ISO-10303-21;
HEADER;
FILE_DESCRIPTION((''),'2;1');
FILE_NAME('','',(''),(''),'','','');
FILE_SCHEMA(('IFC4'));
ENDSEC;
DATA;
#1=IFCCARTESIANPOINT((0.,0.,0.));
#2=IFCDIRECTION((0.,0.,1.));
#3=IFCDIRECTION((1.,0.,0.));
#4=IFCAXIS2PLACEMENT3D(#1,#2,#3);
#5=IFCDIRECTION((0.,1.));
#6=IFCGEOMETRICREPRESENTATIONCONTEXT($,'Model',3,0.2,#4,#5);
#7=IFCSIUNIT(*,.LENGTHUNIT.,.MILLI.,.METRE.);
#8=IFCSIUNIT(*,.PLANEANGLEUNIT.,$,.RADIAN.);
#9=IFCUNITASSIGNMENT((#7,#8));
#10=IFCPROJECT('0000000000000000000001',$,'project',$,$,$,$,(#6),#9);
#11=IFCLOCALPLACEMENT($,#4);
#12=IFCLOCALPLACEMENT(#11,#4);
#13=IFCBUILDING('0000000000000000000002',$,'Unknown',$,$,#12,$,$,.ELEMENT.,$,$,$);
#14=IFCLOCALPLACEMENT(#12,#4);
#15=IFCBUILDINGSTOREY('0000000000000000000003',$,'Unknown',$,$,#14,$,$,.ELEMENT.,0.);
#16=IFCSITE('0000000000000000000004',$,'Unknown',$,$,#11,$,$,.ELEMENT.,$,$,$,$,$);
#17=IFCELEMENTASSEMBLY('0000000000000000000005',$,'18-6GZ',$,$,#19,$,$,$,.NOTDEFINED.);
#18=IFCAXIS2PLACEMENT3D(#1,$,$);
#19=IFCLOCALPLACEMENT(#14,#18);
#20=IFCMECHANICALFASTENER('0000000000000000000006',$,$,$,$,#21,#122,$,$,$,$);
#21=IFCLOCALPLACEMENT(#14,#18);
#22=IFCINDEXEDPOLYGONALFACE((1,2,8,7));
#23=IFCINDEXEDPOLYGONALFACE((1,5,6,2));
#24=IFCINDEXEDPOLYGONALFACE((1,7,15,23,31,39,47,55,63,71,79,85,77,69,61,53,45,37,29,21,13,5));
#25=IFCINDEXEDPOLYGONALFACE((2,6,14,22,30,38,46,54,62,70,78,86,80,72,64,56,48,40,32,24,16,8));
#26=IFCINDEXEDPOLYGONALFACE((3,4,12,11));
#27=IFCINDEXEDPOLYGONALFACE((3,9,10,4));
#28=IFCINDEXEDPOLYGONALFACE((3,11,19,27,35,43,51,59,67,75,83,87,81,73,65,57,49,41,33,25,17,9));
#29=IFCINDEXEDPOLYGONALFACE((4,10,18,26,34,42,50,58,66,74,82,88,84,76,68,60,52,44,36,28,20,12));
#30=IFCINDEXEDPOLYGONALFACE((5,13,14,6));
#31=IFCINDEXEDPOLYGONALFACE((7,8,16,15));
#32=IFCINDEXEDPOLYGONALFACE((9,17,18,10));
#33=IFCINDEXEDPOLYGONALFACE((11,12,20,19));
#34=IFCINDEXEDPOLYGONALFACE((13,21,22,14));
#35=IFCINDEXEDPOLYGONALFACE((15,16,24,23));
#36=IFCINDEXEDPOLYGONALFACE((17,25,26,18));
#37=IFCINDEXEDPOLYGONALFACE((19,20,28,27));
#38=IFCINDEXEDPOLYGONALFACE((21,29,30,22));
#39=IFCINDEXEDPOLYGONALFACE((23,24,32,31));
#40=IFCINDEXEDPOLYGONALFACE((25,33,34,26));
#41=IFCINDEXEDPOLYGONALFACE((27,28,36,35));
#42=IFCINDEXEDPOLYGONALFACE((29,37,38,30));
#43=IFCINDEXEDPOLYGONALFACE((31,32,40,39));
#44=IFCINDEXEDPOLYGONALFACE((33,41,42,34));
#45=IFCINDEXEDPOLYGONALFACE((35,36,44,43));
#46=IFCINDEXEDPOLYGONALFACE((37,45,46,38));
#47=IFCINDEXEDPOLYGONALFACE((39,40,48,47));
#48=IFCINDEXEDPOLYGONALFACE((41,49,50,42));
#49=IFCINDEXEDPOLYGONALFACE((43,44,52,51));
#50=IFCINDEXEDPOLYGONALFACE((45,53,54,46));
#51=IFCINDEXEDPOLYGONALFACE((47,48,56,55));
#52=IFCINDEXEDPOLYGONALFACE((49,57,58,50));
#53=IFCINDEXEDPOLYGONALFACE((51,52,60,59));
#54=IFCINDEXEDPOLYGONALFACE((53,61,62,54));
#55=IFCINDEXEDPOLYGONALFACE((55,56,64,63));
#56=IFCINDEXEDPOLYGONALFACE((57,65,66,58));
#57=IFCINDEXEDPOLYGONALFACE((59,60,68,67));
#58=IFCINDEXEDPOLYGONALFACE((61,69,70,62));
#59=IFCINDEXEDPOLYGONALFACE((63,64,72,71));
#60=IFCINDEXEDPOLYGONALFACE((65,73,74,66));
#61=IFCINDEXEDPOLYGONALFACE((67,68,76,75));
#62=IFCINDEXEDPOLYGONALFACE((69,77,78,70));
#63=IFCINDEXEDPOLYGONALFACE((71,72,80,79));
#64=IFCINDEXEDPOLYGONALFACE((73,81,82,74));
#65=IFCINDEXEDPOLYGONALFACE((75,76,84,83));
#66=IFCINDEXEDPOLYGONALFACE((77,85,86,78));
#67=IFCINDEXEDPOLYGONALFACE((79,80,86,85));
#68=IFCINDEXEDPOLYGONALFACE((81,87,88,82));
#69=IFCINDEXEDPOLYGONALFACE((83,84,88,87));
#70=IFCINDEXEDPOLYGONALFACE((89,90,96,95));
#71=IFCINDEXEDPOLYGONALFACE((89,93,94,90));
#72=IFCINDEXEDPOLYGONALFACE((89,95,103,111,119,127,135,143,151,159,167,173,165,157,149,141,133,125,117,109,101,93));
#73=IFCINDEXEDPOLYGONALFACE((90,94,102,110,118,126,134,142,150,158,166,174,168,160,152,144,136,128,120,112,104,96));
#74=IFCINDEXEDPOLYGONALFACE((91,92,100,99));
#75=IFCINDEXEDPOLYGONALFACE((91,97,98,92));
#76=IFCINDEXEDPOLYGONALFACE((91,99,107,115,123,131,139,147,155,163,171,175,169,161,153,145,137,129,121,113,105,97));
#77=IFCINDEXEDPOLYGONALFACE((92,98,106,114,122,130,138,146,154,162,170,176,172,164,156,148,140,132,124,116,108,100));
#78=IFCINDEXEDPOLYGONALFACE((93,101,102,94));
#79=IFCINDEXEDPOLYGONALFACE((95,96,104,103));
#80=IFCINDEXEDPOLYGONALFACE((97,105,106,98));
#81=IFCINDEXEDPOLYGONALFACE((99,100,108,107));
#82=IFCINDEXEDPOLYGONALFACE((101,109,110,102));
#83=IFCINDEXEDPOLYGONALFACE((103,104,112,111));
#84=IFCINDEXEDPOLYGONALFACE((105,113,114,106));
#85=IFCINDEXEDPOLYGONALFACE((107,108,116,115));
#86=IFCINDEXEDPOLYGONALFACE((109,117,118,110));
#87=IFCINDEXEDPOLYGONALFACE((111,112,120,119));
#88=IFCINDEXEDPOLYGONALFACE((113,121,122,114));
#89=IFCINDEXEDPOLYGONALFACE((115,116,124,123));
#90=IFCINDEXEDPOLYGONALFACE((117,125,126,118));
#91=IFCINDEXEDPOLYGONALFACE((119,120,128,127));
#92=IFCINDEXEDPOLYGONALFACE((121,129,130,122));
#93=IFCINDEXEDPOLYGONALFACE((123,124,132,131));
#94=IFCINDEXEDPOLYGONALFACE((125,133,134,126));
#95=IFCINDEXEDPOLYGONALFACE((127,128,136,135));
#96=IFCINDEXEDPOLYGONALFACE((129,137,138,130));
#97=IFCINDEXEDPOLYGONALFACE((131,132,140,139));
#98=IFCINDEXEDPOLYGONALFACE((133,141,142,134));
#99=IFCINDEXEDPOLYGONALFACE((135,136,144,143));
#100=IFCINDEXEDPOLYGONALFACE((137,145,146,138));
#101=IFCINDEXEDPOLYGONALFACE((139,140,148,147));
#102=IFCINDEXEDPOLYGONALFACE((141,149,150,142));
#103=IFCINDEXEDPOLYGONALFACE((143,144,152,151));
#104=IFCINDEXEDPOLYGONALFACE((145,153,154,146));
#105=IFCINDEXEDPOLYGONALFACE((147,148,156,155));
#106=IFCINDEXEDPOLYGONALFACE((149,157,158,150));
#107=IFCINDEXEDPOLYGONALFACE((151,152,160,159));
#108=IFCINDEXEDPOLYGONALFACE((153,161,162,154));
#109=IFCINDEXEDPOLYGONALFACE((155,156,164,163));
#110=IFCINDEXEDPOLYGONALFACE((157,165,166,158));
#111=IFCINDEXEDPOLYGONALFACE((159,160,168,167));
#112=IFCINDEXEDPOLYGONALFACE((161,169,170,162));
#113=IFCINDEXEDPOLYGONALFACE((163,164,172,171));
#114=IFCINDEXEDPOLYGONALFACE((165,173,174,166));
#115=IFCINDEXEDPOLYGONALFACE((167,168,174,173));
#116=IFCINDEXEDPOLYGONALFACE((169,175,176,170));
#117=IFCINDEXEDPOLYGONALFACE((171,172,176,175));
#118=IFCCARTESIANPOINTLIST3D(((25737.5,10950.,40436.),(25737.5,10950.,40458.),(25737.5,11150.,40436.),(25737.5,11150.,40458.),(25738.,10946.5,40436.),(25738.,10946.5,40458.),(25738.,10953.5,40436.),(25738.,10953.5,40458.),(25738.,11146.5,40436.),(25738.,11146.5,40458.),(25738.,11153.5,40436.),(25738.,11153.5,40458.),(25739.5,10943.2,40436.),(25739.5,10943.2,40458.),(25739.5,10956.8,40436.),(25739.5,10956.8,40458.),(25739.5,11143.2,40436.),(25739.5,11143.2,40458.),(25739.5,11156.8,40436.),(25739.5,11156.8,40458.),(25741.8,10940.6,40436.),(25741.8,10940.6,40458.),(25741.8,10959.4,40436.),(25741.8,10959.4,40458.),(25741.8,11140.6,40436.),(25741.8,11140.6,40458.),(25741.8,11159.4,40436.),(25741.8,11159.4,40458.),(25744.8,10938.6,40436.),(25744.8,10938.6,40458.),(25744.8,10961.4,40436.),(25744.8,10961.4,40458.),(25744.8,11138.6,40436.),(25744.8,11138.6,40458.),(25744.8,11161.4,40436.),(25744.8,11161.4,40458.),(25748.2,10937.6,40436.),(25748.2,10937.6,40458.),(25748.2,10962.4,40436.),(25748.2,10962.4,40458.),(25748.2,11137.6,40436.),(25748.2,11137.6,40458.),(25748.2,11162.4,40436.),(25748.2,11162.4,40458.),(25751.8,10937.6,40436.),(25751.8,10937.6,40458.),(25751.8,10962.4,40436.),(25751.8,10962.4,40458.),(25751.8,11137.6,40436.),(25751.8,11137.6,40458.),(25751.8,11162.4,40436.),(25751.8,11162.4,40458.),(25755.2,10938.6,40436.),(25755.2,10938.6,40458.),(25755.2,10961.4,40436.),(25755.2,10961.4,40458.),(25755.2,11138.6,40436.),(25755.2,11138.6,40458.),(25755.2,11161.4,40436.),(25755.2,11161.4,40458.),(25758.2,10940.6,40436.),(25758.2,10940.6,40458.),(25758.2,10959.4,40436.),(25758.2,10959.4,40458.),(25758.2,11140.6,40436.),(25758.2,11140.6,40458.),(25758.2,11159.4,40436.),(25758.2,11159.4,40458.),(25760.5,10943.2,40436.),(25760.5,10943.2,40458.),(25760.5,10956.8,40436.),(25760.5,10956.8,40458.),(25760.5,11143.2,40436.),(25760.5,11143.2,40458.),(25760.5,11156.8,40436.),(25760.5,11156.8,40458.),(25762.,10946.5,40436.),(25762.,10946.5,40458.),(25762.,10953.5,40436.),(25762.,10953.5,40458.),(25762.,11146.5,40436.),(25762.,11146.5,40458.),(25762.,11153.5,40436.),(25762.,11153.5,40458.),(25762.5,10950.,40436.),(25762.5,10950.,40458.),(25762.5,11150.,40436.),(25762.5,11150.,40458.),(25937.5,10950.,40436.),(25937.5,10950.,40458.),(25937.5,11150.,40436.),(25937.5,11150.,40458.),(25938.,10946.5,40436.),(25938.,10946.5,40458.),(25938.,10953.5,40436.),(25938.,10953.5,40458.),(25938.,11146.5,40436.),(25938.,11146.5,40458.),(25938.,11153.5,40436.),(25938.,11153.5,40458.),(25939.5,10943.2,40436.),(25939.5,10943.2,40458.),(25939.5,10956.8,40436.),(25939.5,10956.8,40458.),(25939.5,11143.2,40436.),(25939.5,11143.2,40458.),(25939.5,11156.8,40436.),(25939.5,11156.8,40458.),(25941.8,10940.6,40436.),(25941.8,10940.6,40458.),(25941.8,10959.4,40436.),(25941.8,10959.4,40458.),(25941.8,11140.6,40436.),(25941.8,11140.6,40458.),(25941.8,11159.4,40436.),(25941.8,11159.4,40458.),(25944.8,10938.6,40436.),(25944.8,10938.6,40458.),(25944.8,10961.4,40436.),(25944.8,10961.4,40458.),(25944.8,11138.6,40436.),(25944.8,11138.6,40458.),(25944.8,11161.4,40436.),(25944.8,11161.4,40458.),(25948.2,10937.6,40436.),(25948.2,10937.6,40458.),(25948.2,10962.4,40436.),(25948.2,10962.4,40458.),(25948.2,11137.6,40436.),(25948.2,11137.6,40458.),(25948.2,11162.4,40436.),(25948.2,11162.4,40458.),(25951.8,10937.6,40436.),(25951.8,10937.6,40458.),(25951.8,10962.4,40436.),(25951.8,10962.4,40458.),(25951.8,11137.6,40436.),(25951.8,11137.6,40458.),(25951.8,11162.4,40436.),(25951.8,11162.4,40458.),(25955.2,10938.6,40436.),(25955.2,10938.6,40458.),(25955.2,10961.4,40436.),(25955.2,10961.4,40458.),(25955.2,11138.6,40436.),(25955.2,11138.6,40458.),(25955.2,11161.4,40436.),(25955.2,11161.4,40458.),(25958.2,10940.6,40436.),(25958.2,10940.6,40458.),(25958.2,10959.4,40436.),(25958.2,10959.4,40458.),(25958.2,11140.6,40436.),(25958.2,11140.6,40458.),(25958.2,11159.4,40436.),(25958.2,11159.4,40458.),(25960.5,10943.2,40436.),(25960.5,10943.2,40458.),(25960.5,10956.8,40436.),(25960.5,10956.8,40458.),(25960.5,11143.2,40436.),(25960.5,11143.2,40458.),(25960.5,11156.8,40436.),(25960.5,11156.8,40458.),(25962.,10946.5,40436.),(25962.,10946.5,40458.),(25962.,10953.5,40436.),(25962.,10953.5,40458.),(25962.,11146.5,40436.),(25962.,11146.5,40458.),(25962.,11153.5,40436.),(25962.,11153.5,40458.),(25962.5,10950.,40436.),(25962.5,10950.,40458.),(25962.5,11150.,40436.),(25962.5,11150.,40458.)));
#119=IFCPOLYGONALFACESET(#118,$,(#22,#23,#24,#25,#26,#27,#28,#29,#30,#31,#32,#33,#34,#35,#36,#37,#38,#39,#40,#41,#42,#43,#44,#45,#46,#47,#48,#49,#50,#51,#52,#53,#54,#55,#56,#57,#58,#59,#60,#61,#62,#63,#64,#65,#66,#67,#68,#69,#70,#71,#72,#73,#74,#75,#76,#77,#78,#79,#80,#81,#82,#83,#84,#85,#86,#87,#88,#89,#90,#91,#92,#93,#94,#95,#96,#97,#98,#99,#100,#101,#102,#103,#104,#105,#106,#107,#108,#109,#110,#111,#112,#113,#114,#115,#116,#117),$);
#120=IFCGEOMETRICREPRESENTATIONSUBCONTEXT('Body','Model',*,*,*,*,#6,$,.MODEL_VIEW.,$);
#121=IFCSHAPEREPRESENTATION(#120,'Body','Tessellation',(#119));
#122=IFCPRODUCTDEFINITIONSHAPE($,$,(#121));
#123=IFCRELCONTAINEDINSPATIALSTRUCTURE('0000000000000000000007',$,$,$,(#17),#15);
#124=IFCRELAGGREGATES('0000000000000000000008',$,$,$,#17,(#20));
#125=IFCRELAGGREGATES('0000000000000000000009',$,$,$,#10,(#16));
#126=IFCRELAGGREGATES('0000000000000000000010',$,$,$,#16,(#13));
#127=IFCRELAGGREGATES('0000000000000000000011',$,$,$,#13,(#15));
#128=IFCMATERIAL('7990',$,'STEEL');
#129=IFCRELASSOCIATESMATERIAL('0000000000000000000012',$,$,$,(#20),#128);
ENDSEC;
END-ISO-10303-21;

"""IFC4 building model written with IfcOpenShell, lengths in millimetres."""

from ifc_helpers import new_model, si_unit, direction, frame, origin_with_axes, place, context, subcontext, project, spatial, arc, indexed_curve, outline, extrude, source, transform, mapped, material, element, aggregate, save


model = new_model("IFC4")

# Units and contexts
model_context = context("Model", 3, precision=0.2, world=origin_with_axes(), true_north=direction((0.0, 1.0)))
body_context = subcontext(model_context, "Body", "Model", "MODEL_VIEW")
ifc_project = project(units=[si_unit("LENGTHUNIT", "METRE", prefix="MILLI"), si_unit("PLANEANGLEUNIT", "RADIAN")], contexts=[model_context])

# Site, building, storey
site_placement = place(None, origin_with_axes())
site = spatial("IfcSite", under=ifc_project, at=site_placement, Name="Unknown", CompositionType="ELEMENT")
building_placement = place(site_placement, origin_with_axes())
building = spatial("IfcBuilding", under=site, at=building_placement, Name="Unknown", CompositionType="ELEMENT")
storey_placement = place(building_placement, origin_with_axes())
storey = spatial("IfcBuildingStorey", under=building, at=storey_placement, Name="Unknown", CompositionType="ELEMENT", Elevation=0.0)

# Element assembly
assembly_1_placement = place(storey_placement, frame((25850.0, 11050.0, 35950.0), z_axis=(-1.0, 0.0, 0.0), x_axis=(0.0, 0.0, 1.0)))
assembly_1 = element("IfcElementAssembly", 1, at=assembly_1_placement, inside=storey, Name="18-6GZ", PredefinedType="NOTDEFINED")

# Mechanical fastener
ifc_material_1 = material(Name="7990", Category="STEEL")
placement_1 = place(assembly_1_placement, frame((4508.0, 0.0, 0.0), z_axis=(1.0, 0.0, 0.0), x_axis=(0.0, 1.0, 0.0)))
shared_shape_1 = source(origin_with_axes(), body_context, "Body", "SweptSolid", [
    extrude(outline(indexed_curve([(12.5, 0.0), (0.0, 12.5), (-12.5, 0.0), (0.0, -12.5)], segments=[arc(1, 2, 3), arc(3, 4, 1)])), frame((0.0, 0.0, 0.0), z_axis=(0.0, 0.0, -1.0), x_axis=(0.0, 1.0, 0.0)), (0.0, 0.0, 1.0), 22.0),
])
mechanical_fastener_1 = element("IfcMechanicalFastener", 2, at=placement_1, material=ifc_material_1, context=body_context, shape_type="MappedRepresentation", body=[
    mapped(shared_shape_1, transform((-100.0, -100.0, 0.0))),
    mapped(shared_shape_1, transform((100.0, -100.0, 0.0))),
    mapped(shared_shape_1, transform((-100.0, 100.0, 0.0))),
    mapped(shared_shape_1, transform((100.0, 100.0, 0.0))),
])
aggregate(assembly_1, [mechanical_fastener_1])

save(model, "model.ifc")
